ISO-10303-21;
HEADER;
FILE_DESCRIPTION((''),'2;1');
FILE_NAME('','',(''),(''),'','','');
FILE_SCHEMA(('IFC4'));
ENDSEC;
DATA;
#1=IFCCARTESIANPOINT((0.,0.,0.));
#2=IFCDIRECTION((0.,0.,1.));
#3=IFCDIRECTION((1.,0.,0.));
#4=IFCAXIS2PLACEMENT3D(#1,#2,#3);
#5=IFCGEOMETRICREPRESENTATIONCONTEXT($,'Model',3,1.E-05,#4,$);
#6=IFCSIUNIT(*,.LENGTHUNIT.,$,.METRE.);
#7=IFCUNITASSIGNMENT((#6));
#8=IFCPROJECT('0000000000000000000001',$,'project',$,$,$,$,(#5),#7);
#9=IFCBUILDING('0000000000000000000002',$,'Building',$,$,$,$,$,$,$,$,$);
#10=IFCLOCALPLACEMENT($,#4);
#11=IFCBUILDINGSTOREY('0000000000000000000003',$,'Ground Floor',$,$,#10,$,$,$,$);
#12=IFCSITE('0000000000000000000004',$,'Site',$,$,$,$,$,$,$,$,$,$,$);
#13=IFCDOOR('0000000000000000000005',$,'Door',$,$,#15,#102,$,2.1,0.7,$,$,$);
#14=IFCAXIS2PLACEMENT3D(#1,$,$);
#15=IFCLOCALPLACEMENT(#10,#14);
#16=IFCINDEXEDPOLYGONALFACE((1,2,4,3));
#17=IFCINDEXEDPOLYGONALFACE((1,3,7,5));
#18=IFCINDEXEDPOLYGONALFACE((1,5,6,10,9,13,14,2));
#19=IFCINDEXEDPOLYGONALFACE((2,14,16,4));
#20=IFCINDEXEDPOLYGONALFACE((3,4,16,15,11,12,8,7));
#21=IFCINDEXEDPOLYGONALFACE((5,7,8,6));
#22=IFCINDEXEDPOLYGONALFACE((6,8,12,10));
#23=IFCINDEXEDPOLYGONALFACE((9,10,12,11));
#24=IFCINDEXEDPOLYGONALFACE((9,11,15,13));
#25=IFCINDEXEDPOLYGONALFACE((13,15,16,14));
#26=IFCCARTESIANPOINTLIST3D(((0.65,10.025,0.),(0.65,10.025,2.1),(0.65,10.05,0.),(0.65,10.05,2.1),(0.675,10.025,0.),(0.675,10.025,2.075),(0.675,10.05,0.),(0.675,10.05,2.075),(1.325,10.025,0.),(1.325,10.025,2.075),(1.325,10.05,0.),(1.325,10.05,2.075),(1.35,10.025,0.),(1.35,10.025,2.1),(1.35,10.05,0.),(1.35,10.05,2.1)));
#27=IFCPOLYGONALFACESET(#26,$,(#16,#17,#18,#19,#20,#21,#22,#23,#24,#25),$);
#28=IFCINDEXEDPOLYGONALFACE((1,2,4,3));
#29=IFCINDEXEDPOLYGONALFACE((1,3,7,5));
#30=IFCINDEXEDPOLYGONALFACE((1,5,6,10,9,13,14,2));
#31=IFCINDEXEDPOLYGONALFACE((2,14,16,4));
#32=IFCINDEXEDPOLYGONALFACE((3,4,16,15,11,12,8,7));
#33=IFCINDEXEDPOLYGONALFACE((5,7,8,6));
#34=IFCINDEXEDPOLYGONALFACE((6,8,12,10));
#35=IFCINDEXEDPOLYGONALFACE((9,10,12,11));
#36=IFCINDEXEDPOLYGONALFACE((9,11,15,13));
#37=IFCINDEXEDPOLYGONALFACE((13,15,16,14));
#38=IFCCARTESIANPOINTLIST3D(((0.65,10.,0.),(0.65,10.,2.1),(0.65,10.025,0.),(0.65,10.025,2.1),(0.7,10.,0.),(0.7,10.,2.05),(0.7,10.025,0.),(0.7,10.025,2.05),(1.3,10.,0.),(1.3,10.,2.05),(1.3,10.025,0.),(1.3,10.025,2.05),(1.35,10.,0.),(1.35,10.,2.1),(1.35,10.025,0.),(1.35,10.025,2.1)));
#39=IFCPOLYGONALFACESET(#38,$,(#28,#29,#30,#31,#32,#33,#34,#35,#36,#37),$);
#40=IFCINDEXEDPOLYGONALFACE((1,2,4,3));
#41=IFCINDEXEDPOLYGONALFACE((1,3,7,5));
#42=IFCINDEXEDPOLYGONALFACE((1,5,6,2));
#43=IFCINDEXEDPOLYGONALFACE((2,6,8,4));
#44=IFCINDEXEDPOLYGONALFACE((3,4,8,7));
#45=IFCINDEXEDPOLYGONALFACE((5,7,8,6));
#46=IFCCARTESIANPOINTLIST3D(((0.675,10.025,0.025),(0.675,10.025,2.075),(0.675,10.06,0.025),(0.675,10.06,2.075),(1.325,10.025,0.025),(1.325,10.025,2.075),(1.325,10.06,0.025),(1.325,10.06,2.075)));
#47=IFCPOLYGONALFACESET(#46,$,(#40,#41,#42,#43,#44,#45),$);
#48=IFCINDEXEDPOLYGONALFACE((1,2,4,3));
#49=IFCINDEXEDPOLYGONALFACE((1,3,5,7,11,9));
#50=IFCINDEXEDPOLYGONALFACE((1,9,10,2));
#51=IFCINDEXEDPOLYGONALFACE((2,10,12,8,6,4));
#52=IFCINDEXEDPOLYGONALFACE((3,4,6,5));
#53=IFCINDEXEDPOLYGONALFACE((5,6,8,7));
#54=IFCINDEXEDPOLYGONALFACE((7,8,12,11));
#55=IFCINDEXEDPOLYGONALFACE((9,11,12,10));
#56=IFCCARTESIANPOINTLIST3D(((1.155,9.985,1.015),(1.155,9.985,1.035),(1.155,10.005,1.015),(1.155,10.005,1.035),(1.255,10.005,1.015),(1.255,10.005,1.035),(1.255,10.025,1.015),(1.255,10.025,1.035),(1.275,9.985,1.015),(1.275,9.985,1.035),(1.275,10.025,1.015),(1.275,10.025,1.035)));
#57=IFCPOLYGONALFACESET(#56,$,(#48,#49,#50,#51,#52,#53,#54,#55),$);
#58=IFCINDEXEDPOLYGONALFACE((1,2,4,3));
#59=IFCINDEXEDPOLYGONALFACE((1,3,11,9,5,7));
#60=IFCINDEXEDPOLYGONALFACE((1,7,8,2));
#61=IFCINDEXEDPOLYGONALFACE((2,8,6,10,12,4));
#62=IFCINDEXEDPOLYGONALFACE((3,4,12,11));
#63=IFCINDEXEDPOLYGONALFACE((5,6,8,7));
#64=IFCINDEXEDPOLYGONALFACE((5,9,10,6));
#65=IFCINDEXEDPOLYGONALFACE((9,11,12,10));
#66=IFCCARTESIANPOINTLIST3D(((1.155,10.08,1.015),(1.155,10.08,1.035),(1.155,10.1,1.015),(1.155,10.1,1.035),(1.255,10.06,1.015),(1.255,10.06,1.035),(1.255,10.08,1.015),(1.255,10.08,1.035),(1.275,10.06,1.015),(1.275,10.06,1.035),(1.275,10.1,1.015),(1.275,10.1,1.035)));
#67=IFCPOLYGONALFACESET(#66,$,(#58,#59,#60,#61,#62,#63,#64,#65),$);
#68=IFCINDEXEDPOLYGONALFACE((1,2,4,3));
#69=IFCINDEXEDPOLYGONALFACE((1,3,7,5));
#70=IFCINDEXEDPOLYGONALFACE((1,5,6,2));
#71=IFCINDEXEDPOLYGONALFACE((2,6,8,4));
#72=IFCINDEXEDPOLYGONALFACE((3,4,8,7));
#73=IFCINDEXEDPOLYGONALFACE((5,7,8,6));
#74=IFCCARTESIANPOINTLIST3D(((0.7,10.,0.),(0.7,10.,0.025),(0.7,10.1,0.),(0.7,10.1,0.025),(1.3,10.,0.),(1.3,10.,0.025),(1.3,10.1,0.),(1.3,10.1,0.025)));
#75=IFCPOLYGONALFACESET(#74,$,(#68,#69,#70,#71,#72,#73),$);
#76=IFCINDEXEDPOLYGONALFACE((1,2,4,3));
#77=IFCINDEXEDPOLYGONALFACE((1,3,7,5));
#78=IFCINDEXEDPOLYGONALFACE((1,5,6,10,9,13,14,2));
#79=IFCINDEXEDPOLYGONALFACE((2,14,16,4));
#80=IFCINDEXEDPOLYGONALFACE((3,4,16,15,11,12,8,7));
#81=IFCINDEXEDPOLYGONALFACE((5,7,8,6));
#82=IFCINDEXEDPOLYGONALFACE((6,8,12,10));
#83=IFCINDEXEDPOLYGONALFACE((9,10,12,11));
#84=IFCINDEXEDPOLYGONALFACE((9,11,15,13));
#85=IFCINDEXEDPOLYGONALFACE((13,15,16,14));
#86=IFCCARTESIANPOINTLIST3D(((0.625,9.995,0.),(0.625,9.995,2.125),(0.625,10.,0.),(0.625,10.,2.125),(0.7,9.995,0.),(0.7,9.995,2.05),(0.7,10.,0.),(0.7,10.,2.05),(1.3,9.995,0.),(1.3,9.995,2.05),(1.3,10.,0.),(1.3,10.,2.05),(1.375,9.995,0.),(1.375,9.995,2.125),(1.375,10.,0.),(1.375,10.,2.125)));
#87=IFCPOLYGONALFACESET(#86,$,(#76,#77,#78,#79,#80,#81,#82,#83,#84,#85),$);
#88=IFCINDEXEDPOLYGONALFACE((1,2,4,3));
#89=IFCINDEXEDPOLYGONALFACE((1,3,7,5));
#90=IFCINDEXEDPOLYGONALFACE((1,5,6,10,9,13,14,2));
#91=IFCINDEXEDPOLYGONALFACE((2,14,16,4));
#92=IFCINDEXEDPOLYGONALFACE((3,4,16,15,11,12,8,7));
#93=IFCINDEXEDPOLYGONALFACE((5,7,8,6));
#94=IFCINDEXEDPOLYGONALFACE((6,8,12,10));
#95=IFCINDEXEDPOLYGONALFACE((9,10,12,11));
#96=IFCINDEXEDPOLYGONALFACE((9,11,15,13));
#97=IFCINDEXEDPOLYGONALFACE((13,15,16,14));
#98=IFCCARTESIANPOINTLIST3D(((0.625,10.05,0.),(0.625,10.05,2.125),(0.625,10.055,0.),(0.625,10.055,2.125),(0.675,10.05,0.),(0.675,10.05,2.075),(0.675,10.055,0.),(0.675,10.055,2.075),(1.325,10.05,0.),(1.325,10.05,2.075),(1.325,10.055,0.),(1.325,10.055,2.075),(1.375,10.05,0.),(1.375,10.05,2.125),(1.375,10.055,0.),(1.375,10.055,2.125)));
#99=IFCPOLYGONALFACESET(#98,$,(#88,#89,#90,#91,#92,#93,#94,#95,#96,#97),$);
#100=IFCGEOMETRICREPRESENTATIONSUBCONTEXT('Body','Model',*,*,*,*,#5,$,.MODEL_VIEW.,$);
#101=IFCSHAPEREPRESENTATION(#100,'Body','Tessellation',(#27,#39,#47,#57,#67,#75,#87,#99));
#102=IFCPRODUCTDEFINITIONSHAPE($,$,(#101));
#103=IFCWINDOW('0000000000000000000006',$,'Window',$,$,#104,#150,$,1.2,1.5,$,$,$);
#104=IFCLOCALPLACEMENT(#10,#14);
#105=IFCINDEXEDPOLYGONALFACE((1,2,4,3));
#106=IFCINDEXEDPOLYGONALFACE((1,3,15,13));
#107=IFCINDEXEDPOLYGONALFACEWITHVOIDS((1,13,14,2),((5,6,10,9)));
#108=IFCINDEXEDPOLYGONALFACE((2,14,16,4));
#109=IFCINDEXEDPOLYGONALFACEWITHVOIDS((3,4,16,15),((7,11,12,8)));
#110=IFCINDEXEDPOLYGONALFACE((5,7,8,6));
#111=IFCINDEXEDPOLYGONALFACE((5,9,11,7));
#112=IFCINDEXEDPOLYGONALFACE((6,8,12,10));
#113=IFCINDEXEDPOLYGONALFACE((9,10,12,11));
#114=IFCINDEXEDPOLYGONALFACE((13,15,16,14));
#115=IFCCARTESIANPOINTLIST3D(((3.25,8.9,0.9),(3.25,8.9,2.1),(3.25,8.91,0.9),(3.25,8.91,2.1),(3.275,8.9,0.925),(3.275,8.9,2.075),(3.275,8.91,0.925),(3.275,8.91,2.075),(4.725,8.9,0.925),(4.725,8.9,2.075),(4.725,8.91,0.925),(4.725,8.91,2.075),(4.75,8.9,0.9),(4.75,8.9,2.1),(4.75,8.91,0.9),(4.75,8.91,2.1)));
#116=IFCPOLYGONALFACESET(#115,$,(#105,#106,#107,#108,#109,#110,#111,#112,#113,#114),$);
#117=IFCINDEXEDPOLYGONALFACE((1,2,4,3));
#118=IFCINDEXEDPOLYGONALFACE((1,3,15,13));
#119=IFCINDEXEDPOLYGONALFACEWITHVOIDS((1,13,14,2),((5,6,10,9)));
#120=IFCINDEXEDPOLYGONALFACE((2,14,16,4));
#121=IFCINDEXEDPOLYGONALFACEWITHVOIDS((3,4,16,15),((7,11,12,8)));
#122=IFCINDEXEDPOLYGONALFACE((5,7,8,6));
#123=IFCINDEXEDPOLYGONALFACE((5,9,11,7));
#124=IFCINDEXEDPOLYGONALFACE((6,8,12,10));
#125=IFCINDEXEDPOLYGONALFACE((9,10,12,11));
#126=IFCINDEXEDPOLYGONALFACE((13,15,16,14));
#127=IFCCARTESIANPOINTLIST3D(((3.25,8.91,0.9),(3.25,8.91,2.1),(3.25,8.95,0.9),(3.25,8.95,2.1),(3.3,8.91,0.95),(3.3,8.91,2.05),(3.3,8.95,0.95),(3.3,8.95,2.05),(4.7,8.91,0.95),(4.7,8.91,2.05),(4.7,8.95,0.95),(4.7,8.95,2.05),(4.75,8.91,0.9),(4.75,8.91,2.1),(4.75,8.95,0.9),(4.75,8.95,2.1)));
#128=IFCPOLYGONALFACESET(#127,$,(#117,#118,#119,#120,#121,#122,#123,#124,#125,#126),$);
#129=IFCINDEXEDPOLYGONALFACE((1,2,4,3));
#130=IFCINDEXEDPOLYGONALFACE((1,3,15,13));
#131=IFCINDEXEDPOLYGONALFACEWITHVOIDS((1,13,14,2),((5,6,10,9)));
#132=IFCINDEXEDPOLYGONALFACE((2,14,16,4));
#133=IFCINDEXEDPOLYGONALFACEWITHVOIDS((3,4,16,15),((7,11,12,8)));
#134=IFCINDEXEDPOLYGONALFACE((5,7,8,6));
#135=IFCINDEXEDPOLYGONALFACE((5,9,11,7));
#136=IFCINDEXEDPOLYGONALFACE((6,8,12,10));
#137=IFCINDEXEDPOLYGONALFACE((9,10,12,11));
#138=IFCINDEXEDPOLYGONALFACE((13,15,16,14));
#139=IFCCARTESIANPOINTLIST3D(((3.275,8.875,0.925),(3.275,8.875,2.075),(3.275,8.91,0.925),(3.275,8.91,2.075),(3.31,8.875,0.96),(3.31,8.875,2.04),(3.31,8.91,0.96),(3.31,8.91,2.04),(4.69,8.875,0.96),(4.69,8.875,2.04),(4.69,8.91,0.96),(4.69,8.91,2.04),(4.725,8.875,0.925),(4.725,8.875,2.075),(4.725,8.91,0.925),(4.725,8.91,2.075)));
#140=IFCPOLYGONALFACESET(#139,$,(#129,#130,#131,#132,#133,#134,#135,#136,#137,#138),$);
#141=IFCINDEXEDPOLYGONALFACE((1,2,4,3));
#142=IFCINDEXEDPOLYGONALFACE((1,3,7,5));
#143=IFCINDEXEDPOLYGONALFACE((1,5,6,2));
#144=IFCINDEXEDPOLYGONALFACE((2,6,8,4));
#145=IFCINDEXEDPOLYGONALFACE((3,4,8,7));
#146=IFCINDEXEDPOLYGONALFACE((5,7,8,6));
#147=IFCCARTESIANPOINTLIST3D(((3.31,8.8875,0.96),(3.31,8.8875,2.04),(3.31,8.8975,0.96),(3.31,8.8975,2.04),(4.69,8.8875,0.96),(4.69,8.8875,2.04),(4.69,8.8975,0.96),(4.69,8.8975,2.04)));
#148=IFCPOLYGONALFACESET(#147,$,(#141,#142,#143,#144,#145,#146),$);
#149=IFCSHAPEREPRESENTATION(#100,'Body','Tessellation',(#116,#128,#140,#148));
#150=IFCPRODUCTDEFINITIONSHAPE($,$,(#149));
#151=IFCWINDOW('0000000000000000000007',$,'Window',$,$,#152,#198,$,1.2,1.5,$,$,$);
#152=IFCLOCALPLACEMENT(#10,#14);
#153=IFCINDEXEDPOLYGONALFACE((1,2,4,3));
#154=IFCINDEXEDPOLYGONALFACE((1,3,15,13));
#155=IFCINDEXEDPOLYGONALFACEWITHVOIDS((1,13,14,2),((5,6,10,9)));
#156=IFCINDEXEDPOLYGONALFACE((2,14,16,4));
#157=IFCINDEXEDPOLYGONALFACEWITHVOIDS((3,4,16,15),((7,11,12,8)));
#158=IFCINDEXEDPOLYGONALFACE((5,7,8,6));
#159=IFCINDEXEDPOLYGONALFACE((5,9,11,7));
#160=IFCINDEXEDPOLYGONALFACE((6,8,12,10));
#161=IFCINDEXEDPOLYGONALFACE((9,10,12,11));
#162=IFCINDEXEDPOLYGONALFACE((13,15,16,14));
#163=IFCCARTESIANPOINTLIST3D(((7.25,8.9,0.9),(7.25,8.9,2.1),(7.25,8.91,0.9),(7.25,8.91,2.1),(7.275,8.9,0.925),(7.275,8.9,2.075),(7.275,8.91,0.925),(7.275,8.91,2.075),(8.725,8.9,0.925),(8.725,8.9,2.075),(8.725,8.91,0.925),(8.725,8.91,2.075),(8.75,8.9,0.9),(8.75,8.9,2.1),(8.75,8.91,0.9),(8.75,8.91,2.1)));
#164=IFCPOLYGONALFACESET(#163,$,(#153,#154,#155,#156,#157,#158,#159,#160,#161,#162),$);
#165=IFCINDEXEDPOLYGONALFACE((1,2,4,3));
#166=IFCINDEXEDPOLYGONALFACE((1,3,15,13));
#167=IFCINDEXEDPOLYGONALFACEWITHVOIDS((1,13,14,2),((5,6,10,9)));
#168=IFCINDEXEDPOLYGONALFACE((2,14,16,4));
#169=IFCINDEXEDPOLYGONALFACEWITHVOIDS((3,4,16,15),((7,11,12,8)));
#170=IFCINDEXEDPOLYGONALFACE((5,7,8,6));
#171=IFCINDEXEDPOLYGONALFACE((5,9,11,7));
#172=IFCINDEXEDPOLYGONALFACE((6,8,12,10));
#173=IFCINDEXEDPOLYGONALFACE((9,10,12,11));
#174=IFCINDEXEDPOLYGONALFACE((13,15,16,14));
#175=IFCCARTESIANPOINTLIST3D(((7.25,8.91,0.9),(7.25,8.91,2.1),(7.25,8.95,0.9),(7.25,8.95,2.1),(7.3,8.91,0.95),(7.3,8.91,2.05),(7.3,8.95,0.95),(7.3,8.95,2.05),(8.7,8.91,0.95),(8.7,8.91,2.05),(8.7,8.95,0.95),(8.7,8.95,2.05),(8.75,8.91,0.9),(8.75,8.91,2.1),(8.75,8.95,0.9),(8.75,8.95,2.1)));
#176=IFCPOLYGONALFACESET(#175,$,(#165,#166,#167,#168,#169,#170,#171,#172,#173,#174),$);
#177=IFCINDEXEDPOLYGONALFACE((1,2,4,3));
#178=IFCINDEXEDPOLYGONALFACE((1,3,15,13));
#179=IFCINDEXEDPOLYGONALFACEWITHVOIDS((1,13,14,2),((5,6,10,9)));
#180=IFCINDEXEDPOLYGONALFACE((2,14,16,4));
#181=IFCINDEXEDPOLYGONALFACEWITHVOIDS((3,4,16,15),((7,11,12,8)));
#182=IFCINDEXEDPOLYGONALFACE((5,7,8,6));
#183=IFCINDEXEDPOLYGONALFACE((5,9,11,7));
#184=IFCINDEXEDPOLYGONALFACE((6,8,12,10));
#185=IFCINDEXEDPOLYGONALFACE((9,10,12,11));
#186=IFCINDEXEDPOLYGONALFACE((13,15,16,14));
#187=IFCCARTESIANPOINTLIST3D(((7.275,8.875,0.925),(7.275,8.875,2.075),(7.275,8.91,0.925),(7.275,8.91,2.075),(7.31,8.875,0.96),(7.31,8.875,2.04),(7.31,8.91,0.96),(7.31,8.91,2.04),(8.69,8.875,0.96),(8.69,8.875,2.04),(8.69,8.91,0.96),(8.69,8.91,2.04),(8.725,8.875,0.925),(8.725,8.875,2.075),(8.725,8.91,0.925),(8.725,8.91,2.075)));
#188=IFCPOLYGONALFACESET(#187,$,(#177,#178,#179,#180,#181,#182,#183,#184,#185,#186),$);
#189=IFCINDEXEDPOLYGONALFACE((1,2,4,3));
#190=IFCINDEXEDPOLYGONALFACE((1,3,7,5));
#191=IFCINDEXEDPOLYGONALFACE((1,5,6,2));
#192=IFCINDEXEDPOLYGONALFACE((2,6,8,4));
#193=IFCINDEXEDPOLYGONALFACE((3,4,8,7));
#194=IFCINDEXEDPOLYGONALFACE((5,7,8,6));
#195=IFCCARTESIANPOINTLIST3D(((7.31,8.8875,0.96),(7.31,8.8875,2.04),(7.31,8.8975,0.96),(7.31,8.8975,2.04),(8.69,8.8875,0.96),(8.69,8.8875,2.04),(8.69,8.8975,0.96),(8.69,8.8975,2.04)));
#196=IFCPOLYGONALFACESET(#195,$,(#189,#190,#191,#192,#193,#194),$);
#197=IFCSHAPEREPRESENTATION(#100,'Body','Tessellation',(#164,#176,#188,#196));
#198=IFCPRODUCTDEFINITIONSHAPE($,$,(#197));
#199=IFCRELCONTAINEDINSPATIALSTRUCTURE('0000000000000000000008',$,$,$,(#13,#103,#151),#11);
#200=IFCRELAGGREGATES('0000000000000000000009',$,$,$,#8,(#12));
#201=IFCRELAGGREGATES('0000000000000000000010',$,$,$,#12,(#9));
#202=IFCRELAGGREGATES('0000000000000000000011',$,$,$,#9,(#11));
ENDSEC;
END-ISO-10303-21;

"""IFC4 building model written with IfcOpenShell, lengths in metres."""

from ifc_helpers import new_model, si_unit, frame, origin_with_axes, place, context, subcontext, project, spatial, line, indexed_curve, outline, extrude, element, save


model = new_model("IFC4")

# Units and contexts
model_context = context("Model", 3, precision=1e-05, world=origin_with_axes())
body_context = subcontext(model_context, "Body", "Model", "MODEL_VIEW")
ifc_project = project(units=[si_unit("LENGTHUNIT", "METRE")], contexts=[model_context])

# Site, building, storey
site = spatial("IfcSite", under=ifc_project, Name="Site")
building = spatial("IfcBuilding", under=site, Name="Building")
storey_placement = place(None, origin_with_axes())
storey = spatial("IfcBuildingStorey", under=building, at=storey_placement, Name="Ground Floor")

# Door
door_1_placement = place(storey_placement, frame((0.65, 10.0, 0.0), z_axis=(0.0, 0.0, 1.0), x_axis=(1.0, 0.0, 0.0)))
element("IfcDoor", 1, at=door_1_placement, inside=storey, Name="Door", OverallHeight=2.1, OverallWidth=0.7, context=body_context, shape_type="SweptSolid", body=[
    extrude(outline(indexed_curve([(0.0, 0.0), (0.0, 2.1), (0.7, 2.1), (0.7, 0.0), (0.675, 0.0), (0.675, 2.075), (0.025, 2.075), (0.025, 0.0)], segments=[line(1, 2, 3, 4, 5, 6, 7, 8, 1)])), frame((0.0, 0.025, 0.0), z_axis=(0.0, -1.0, 0.0), x_axis=(1.0, 0.0, 0.0)), (0.0, 0.0, -1.0), 0.025),
    extrude(outline(indexed_curve([(0.0, 0.0), (0.0, 2.1), (0.7, 2.1), (0.7, 0.0), (0.65, 0.0), (0.65, 2.05), (0.05, 2.05), (0.05, 0.0)], segments=[line(1, 2, 3, 4, 5, 6, 7, 8, 1)])), frame((0.0, 0.0, 0.0), z_axis=(0.0, -1.0, 0.0), x_axis=(1.0, 0.0, 0.0)), (0.0, 0.0, -1.0), 0.025),
    extrude(outline(indexed_curve([(0.0, 0.0), (0.65, 0.0), (0.65, 0.035), (0.0, 0.035)], segments=[line(1, 2, 3, 4, 1)])), frame((0.025, 0.025, 0.025), z_axis=(0.0, 0.0, 1.0), x_axis=(1.0, 0.0, 0.0)), (0.0, 0.0, 1.0), 2.05),
    extrude(outline(indexed_curve([(0.0, 0.0), (0.0, -0.04), (-0.12, -0.04), (-0.12, -0.02), (-0.02, -0.02), (-0.02, 0.0)], segments=[line(1, 2, 3, 4, 5, 6, 1)])), frame((0.625, 0.025, 1.015), z_axis=(0.0, 0.0, 1.0), x_axis=(1.0, 0.0, 0.0)), (0.0, 0.0, 1.0), 0.02),
    extrude(outline(indexed_curve([(0.0, 0.0), (0.0, 0.04), (-0.12, 0.04), (-0.12, 0.02), (-0.02, 0.02), (-0.02, 0.0)], segments=[line(1, 2, 3, 4, 5, 6, 1)])), frame((0.625, 0.06, 1.015), z_axis=(0.0, 0.0, 1.0), x_axis=(1.0, 0.0, 0.0)), (0.0, 0.0, 1.0), 0.02),
    extrude(outline(indexed_curve([(0.0, 0.0), (0.6, 0.0), (0.6, 0.1), (0.0, 0.1)], segments=[line(1, 2, 3, 4, 1)])), frame((0.05, 0.0, 0.0), z_axis=(0.0, 0.0, 1.0), x_axis=(1.0, 0.0, 0.0)), (0.0, 0.0, 1.0), 0.025),
    extrude(outline(indexed_curve([(0.0, 0.0), (0.0, 2.125), (0.75, 2.125), (0.75, 0.0), (0.675, 0.0), (0.675, 2.05), (0.075, 2.05), (0.075, 0.0)], segments=[line(1, 2, 3, 4, 5, 6, 7, 8, 1)])), frame((-0.025, -0.005, 0.0), z_axis=(0.0, -1.0, 0.0), x_axis=(1.0, 0.0, 0.0)), (0.0, 0.0, -1.0), 0.005),
    extrude(outline(indexed_curve([(0.0, 0.0), (0.0, 2.125), (0.75, 2.125), (0.75, 0.0), (0.7, 0.0), (0.7, 2.075), (0.05, 2.075), (0.05, 0.0)], segments=[line(1, 2, 3, 4, 5, 6, 7, 8, 1)])), frame((-0.025, 0.05, 0.0), z_axis=(0.0, -1.0, 0.0), x_axis=(1.0, 0.0, 0.0)), (0.0, 0.0, -1.0), 0.005),
])

# Windows
for number, where, z_axis, x_axis, name in (
    (2, (4.75, 9.0, 0.9), (0.0, 0.0, 1.0), (-1.0, 0.0, 0.0), "Window"),
    (3, (8.75, 9.0, 0.9), (0.0, 0.0, 1.0), (-1.0, 0.0, 0.0), "Window"),
):
    element("IfcWindow", number, at=place(storey_placement, frame(where, z_axis=z_axis, x_axis=x_axis)), inside=storey, Name=name, OverallHeight=1.2, OverallWidth=1.5, context=body_context, shape_type="SweptSolid", body=[
        extrude(outline(indexed_curve([(0.0, 0.0), (1.5, 0.0), (1.5, 1.2), (0.0, 1.2)], segments=[line(1, 2, 3, 4, 1)]), holes=[indexed_curve([(0.025, 0.025), (1.475, 0.025), (1.475, 1.175), (0.025, 1.175)], segments=[line(1, 2, 3, 4, 1)])]), frame((0.0, 0.09, 0.0), z_axis=(0.0, -1.0, 0.0), x_axis=(1.0, 0.0, 0.0)), (0.0, 0.0, -1.0), 0.01),
        extrude(outline(indexed_curve([(0.0, 0.0), (1.5, 0.0), (1.5, 1.2), (0.0, 1.2)], segments=[line(1, 2, 3, 4, 1)]), holes=[indexed_curve([(0.05, 0.05), (1.45, 0.05), (1.45, 1.15), (0.05, 1.15)], segments=[line(1, 2, 3, 4, 1)])]), frame((0.0, 0.05, 0.0), z_axis=(0.0, -1.0, 0.0), x_axis=(1.0, 0.0, 0.0)), (0.0, 0.0, -1.0), 0.04),
        extrude(outline(indexed_curve([(0.0, 0.0), (1.45, 0.0), (1.45, 1.15), (0.0, 1.15)], segments=[line(1, 2, 3, 4, 1)]), holes=[indexed_curve([(0.035, 0.035), (1.415, 0.035), (1.415, 1.115), (0.035, 1.115)], segments=[line(1, 2, 3, 4, 1)])]), frame((0.025, 0.09, 0.025), z_axis=(0.0, -1.0, 0.0), x_axis=(1.0, 0.0, 0.0)), (0.0, 0.0, -1.0), 0.035),
        extrude(outline(indexed_curve([(0.035, 0.035), (1.415, 0.035), (1.415, 1.115), (0.035, 1.115)], segments=[line(1, 2, 3, 4, 1)])), frame((0.025, 0.1025, 0.025), z_axis=(0.0, -1.0, 0.0), x_axis=(1.0, 0.0, 0.0)), (0.0, 0.0, -1.0), 0.01),
    ])

save(model, "model.ifc")
